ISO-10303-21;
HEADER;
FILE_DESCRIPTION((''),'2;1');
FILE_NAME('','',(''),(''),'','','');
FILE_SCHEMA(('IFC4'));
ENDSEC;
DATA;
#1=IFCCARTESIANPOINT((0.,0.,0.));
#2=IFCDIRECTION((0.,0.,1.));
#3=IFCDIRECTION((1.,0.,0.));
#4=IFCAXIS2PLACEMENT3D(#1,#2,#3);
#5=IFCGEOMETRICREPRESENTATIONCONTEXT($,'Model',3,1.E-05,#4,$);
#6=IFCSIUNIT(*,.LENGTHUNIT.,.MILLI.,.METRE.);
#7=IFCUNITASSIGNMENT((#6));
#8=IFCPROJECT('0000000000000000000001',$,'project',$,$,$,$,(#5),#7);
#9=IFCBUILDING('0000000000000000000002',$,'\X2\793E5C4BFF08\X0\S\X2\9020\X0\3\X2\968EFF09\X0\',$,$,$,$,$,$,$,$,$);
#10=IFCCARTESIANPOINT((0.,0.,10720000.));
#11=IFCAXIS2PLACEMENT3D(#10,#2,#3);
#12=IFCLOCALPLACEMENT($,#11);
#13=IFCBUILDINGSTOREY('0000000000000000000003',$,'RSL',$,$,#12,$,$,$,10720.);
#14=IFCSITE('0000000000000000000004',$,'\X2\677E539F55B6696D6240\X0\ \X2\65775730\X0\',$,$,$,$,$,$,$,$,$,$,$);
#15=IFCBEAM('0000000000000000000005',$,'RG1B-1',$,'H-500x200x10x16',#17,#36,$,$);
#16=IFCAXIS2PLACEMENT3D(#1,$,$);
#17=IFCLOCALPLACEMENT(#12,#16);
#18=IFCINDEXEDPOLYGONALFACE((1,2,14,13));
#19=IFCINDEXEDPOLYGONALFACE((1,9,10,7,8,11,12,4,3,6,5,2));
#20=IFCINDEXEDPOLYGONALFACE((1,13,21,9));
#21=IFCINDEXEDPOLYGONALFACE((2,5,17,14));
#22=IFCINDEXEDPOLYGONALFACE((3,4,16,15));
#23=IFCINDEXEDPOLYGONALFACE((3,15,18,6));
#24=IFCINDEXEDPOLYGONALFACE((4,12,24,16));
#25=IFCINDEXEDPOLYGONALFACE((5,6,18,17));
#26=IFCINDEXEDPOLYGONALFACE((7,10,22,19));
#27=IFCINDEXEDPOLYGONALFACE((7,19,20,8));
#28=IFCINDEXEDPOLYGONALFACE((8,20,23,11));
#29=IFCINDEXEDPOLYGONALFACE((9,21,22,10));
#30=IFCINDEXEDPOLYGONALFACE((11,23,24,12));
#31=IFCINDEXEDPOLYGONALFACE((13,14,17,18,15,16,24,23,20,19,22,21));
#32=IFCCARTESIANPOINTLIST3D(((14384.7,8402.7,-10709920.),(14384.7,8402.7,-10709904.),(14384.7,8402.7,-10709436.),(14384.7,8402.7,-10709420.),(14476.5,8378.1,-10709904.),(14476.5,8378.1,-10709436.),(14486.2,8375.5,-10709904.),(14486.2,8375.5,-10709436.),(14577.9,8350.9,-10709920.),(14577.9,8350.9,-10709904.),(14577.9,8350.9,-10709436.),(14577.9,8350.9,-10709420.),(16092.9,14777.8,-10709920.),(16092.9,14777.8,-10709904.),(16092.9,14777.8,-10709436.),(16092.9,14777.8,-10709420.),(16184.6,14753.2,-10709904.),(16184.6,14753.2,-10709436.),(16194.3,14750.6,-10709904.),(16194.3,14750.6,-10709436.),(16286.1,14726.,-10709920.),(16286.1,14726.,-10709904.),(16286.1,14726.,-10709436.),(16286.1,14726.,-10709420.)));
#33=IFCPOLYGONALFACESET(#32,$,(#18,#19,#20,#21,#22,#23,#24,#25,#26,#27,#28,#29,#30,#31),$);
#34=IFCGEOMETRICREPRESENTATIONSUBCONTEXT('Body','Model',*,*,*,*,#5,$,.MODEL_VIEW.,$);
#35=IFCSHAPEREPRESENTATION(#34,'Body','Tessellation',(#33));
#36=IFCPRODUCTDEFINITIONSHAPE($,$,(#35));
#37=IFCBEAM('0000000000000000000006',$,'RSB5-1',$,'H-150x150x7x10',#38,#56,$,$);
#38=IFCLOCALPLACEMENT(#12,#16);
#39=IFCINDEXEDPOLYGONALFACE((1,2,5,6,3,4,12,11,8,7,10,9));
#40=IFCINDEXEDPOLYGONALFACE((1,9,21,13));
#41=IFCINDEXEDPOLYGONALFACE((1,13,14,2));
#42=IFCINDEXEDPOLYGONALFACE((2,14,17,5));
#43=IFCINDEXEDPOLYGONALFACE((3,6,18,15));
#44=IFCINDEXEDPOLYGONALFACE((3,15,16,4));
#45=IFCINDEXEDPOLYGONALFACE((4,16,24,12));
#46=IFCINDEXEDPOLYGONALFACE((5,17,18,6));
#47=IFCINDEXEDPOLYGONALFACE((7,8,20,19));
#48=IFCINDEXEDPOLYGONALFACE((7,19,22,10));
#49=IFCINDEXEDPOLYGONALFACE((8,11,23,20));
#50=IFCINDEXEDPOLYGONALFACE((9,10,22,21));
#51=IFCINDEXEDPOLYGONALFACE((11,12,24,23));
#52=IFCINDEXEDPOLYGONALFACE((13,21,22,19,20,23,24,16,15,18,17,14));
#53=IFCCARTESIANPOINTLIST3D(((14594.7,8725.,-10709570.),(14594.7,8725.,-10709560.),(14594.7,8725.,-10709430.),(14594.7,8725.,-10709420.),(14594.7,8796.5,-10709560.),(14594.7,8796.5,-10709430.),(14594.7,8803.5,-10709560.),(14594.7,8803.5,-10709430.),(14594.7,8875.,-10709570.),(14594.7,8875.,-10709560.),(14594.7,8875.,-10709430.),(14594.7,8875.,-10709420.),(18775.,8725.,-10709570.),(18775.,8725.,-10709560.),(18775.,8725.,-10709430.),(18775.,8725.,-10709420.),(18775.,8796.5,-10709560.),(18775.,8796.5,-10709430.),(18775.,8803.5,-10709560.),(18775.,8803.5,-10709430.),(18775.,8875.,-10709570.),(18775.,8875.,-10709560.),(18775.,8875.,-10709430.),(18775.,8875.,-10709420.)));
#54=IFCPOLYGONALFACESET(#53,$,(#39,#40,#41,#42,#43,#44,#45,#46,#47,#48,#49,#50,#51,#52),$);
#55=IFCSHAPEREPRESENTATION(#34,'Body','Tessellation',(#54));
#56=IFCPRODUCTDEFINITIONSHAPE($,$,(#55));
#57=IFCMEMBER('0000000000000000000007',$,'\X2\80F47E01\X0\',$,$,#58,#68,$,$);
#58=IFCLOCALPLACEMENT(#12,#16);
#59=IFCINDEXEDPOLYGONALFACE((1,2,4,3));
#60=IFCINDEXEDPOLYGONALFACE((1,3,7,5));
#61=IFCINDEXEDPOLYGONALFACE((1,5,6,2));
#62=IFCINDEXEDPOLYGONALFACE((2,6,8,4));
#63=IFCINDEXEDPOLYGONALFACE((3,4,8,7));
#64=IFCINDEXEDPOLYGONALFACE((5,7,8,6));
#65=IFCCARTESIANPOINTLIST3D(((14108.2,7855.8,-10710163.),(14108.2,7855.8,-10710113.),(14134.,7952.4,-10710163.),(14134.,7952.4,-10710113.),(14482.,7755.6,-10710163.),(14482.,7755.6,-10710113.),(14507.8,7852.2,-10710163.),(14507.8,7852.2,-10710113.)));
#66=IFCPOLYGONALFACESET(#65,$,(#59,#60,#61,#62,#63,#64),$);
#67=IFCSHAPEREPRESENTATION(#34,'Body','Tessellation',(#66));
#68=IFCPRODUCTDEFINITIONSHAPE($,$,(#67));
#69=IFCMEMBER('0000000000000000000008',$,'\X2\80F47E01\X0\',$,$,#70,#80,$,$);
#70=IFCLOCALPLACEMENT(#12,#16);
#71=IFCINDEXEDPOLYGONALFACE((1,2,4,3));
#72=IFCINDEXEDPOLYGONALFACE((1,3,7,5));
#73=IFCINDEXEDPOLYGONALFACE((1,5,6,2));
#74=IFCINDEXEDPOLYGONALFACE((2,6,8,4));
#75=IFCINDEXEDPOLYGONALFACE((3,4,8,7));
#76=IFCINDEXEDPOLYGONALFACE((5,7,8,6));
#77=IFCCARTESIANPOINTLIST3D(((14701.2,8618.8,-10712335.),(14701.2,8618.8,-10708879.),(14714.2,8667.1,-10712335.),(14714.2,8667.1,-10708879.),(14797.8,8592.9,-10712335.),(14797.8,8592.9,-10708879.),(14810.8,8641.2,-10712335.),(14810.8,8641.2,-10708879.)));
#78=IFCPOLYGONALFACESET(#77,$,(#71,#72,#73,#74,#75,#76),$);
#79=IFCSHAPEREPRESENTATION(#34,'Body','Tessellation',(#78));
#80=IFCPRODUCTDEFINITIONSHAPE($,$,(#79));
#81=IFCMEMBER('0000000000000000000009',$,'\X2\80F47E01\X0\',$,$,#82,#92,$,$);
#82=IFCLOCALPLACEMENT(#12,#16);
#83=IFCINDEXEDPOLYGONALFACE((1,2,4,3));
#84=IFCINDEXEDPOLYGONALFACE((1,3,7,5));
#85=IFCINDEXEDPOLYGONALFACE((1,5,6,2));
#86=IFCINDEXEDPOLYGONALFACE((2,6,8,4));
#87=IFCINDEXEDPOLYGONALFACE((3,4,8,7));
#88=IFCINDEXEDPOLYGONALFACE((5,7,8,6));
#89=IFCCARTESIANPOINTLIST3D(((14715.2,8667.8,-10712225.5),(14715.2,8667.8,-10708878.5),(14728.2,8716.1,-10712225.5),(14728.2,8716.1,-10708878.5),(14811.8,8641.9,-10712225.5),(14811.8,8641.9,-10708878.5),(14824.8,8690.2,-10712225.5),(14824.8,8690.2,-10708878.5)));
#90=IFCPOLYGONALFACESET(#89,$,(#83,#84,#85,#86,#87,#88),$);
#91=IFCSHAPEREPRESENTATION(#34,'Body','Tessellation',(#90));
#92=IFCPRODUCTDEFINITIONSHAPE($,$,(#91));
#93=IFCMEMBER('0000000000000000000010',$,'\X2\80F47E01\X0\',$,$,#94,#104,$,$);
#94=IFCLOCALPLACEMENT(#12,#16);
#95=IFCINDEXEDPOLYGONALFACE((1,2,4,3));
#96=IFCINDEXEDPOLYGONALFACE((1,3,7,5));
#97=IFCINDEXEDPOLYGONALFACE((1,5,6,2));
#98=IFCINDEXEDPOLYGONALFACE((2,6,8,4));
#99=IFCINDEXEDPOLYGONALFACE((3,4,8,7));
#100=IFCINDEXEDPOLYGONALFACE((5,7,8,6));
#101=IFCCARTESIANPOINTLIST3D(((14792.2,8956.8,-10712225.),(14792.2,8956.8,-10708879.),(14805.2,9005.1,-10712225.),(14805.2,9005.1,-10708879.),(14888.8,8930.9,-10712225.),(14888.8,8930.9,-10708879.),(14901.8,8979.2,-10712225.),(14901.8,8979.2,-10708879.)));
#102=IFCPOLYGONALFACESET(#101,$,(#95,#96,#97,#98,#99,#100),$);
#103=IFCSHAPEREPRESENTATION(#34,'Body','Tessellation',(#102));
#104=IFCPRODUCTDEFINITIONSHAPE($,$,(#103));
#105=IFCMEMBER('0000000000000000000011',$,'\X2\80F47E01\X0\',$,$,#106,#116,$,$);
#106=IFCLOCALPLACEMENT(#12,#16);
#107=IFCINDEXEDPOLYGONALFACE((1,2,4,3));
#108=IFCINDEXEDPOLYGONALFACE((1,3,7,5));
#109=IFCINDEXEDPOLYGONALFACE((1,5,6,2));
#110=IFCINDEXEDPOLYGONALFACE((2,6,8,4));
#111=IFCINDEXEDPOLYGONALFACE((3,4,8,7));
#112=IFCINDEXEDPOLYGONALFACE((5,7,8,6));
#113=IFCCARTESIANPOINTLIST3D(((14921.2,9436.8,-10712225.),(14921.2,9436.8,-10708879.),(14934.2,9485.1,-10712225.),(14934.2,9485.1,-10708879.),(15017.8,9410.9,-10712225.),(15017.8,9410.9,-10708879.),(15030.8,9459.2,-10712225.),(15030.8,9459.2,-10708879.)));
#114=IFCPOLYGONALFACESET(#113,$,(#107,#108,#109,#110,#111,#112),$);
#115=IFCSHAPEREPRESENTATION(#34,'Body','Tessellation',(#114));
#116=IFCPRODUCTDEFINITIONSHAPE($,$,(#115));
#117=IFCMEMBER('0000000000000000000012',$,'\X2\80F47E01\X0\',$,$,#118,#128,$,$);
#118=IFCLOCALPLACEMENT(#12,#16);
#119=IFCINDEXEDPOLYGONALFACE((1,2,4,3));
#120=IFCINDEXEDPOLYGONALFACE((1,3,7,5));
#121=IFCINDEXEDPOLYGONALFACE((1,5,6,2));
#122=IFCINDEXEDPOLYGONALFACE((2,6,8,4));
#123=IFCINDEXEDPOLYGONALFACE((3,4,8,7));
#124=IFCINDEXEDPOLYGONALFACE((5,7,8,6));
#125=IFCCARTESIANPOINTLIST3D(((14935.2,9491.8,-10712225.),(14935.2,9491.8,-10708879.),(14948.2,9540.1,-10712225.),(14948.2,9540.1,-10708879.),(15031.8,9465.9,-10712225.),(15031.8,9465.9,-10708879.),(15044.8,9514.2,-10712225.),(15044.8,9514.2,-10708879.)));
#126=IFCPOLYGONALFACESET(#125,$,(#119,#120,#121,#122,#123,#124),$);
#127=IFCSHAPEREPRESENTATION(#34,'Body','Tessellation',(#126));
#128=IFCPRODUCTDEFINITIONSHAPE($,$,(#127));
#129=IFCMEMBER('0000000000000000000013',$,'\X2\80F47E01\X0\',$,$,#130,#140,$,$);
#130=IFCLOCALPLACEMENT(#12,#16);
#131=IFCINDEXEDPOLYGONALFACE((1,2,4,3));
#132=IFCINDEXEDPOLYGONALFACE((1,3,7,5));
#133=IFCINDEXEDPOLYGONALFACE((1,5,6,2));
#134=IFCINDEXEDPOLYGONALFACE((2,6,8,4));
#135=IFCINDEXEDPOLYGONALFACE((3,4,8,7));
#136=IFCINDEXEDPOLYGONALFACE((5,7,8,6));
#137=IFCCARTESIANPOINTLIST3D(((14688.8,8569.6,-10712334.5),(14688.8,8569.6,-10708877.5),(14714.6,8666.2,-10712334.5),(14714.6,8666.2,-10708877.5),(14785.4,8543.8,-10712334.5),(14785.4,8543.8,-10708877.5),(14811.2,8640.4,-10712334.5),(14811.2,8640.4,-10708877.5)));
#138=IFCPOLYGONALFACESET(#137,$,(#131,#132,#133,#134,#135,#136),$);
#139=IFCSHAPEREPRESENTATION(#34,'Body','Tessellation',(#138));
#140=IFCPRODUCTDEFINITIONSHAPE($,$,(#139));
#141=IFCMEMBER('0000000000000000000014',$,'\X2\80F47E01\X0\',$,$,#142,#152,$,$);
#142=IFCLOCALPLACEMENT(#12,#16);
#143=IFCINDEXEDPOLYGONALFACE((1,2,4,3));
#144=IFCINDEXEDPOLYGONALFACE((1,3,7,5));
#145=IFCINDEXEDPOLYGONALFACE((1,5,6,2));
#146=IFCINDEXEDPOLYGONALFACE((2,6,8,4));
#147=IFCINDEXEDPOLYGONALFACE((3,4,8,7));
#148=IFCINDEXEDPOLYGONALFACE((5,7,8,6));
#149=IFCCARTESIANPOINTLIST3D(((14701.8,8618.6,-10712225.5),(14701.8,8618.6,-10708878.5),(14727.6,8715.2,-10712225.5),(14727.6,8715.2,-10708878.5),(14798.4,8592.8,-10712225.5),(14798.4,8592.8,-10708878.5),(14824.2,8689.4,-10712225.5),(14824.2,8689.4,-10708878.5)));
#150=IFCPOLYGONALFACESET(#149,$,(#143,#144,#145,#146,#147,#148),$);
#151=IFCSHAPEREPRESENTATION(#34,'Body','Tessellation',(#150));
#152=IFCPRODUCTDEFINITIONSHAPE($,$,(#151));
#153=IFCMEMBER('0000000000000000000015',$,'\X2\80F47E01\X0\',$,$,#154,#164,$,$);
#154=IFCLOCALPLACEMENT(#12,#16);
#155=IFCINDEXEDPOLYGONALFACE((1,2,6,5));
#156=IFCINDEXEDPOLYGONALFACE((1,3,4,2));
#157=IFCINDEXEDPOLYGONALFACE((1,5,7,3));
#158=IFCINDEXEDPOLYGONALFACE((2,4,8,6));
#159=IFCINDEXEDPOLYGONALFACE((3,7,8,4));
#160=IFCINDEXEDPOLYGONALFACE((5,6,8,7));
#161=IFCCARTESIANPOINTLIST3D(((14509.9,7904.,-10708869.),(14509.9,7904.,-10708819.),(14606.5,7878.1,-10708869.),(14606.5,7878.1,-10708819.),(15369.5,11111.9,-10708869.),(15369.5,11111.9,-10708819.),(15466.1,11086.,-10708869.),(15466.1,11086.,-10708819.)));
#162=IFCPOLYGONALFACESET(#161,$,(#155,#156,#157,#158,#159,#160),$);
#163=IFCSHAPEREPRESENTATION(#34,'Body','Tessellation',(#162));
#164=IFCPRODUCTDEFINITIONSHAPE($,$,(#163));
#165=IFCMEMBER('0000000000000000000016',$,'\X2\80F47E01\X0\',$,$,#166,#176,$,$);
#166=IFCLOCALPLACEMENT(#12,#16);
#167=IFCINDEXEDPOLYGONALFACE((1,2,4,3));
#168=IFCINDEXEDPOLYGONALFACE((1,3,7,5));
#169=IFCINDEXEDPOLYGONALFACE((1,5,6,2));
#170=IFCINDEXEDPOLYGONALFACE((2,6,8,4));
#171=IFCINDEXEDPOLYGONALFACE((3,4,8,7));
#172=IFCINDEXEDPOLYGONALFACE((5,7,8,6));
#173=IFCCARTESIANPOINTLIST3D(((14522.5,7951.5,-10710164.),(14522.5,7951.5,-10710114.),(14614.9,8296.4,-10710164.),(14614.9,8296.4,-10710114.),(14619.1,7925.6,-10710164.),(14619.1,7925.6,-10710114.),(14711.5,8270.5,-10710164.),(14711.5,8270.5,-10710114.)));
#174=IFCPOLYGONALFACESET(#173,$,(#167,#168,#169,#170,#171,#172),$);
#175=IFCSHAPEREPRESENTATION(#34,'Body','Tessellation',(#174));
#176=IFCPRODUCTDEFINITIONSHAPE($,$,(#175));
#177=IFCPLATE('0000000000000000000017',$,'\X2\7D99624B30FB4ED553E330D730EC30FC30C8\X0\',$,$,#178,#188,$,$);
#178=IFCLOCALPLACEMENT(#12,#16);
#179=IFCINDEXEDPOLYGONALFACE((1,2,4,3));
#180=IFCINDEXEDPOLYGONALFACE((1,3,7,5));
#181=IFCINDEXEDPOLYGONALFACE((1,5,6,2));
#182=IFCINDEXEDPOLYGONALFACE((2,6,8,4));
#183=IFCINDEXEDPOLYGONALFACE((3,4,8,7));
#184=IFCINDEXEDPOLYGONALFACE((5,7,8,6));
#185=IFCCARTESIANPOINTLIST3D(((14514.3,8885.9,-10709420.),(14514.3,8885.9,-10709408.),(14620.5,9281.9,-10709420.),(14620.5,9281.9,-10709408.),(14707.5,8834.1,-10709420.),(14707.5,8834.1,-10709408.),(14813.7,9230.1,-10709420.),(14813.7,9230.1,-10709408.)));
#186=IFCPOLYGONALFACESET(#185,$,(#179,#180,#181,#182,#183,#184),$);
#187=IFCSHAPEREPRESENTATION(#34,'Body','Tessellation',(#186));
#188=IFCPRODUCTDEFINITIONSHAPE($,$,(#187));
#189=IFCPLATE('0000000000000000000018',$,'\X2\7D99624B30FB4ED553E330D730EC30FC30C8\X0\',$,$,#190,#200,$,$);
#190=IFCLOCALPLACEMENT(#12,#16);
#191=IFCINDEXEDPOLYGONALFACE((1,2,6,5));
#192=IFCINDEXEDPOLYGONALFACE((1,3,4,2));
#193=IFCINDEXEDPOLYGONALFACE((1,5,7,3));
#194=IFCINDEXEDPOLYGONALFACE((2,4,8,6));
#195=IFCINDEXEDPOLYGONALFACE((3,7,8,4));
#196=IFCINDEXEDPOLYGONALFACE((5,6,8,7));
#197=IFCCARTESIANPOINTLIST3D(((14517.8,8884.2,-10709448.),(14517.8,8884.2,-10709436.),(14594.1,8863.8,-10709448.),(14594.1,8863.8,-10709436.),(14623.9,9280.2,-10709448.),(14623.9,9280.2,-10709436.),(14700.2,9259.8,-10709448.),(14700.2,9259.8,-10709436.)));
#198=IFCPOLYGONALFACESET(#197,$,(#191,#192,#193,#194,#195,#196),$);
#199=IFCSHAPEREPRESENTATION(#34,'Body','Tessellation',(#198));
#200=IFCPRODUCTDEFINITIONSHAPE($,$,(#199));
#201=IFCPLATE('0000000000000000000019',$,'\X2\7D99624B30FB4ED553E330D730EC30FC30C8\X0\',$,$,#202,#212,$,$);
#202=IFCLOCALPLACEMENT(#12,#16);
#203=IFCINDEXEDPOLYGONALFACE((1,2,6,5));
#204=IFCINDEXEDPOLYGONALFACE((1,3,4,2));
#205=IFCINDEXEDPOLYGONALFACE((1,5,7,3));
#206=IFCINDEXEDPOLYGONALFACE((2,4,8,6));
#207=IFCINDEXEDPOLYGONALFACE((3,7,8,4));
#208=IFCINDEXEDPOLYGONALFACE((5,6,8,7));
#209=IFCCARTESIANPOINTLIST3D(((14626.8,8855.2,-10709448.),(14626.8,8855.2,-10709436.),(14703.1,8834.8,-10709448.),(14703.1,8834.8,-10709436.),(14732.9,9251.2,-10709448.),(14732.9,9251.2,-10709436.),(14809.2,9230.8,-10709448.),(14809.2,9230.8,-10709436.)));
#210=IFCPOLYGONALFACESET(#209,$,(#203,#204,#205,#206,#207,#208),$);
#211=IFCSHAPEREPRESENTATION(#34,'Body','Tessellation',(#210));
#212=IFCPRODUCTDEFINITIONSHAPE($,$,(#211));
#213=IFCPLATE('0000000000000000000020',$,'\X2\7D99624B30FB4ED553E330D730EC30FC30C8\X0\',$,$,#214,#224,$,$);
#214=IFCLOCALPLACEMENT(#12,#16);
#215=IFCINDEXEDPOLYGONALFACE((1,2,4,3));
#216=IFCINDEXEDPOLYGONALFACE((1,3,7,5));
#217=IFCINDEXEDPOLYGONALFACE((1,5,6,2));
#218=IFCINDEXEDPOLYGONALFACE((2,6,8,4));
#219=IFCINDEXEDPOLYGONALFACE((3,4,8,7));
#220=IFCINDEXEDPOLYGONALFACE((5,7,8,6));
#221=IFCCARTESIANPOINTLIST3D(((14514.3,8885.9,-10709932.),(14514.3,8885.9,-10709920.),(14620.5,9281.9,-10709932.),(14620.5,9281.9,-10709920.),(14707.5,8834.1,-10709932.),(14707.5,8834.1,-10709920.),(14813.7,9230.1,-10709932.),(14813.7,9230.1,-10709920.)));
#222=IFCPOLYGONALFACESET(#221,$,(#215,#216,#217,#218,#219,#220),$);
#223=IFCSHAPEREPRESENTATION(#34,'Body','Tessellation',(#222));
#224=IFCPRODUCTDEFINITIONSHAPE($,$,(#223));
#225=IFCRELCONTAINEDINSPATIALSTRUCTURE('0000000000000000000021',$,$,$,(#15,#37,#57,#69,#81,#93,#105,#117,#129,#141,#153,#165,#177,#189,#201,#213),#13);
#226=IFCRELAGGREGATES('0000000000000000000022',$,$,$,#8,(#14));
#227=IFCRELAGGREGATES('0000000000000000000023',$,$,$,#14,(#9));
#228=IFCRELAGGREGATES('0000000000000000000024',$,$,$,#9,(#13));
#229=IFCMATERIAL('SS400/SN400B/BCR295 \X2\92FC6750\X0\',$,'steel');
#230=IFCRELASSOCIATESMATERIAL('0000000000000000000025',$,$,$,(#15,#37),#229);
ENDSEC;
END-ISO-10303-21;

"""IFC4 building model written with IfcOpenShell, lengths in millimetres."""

from ifc_helpers import new_model, si_unit, frame, origin, origin_with_axes, place, context, subcontext, project, spatial, rectangle, i_section, extrude, material, element, save


model = new_model("IFC4")

# Units and contexts
model_context = context("Model", 3, precision=1e-05, world=origin_with_axes())
body_context = subcontext(model_context, "Body", "Model", "MODEL_VIEW")
ifc_project = project(units=[si_unit("LENGTHUNIT", "METRE", prefix="MILLI")], contexts=[model_context])

# Site, building, storey
site = spatial("IfcSite", under=ifc_project, Name="松原営業所 敷地")
building = spatial("IfcBuilding", under=site, Name="社屋（S造3階）")
storey_placement = place(None, frame((0.0, 0.0, 10720000.0), z_axis=(0.0, 0.0, 1.0), x_axis=(1.0, 0.0, 0.0)))
storey = spatial("IfcBuildingStorey", under=building, at=storey_placement, Name="RSL", Elevation=10720.0)

# Beams
ifc_material = material(Name="SS400/SN400B/BCR295 鋼材", Category="steel")
beam_1_placement = place(storey_placement, frame((14481.3, 8376.8, -10709420.0), z_axis=(0.258812, 0.965928, 0.0), x_axis=(-0.965928, 0.258812, 0.0)))
element("IfcBeam", 1, at=beam_1_placement, inside=storey, material=ifc_material, Name="RG1B-1", ObjectType="H-500x200x10x16", context=body_context, shape_type="SweptSolid", body=[
    extrude(i_section(OverallWidth=200.0, OverallDepth=500.0, WebThickness=10.0, FlangeThickness=16.0), frame((0.0, -250.0, 0.0)), (0.0, 0.0, 1.0), 6600.0),
])
beam_2_placement = place(storey_placement, frame((14594.7, 8800.0, -10709420.0), z_axis=(1.0, 0.0, 0.0), x_axis=(0.0, 1.0, 0.0)))
element("IfcBeam", 2, at=beam_2_placement, inside=storey, material=ifc_material, Name="RSB5-1", ObjectType="H-150x150x7x10", context=body_context, shape_type="SweptSolid", body=[
    extrude(i_section(OverallWidth=150.0, OverallDepth=150.0, WebThickness=7.0, FlangeThickness=10.0), frame((0.0, -75.0, 0.0)), (0.0, 0.0, 1.0), 4180.3),
])

# Members
member_1_placement = place(storey_placement, frame((14121.1, 7904.1, -10710138.0), z_axis=(0.965926, -0.258819, 0.0), x_axis=(0.258819, 0.965926, 0.0)))
element("IfcMember", 3, at=member_1_placement, inside=storey, Name="胴縁", context=body_context, shape_type="SweptSolid", body=[
    extrude(rectangle(XDim=100.0, YDim=50.0), origin(), (0.0, 0.0, 1.0), 387.0),
])
member_2_placement = place(storey_placement, frame((14749.5, 8605.9, -10710607.0), z_axis=(0.258819, 0.965926, 0.0), x_axis=(-0.965926, 0.258819, 0.0)))
element("IfcMember", 4, at=member_2_placement, inside=storey, Name="胴縁", context=body_context, shape_type="SweptSolid", body=[
    extrude(rectangle(XDim=100.0, YDim=3456.0), origin(), (0.0, 0.0, 1.0), 50.0),
])
member_3_placement = place(storey_placement, frame((14763.5, 8654.9, -10710552.0), z_axis=(0.258819, 0.965926, 0.0), x_axis=(-0.965926, 0.258819, 0.0)))
element("IfcMember", 5, at=member_3_placement, inside=storey, Name="胴縁", context=body_context, shape_type="SweptSolid", body=[
    extrude(rectangle(XDim=100.0, YDim=3347.0), origin(), (0.0, 0.0, 1.0), 50.0),
])
for number, where, z_axis, x_axis, name in (
    (6, (14840.5, 8943.9, -10710552.0), (0.258819, 0.965926, 0.0), (-0.965926, 0.258819, 0.0), "胴縁"),
    (7, (14969.5, 9423.9, -10710552.0), (0.258819, 0.965926, 0.0), (-0.965926, 0.258819, 0.0), "胴縁"),
    (8, (14983.5, 9478.9, -10710552.0), (0.258819, 0.965926, 0.0), (-0.965926, 0.258819, 0.0), "胴縁"),
):
    element("IfcMember", number, at=place(storey_placement, frame(where, z_axis=z_axis, x_axis=x_axis)), inside=storey, Name=name, context=body_context, shape_type="SweptSolid", body=[
        extrude(rectangle(XDim=100.0, YDim=3346.0), origin(), (0.0, 0.0, 1.0), 50.0),
    ])
member_4_placement = place(storey_placement, frame((14737.1, 8556.7, -10710606.0), z_axis=(0.258819, 0.965926, 0.0), x_axis=(-0.965926, 0.258819, 0.0)))
element("IfcMember", 9, at=member_4_placement, inside=storey, Name="胴縁", context=body_context, shape_type="SweptSolid", body=[
    extrude(rectangle(XDim=100.0, YDim=3457.0), origin(), (0.0, 0.0, 1.0), 100.0),
])
member_5_placement = place(storey_placement, frame((14750.1, 8605.7, -10710552.0), z_axis=(0.258819, 0.965926, 0.0), x_axis=(-0.965926, 0.258819, 0.0)))
element("IfcMember", 10, at=member_5_placement, inside=storey, Name="胴縁", context=body_context, shape_type="SweptSolid", body=[
    extrude(rectangle(XDim=100.0, YDim=3347.0), origin(), (0.0, 0.0, 1.0), 100.0),
])
member_6_placement = place(storey_placement, frame((14558.2, 7891.1, -10708844.0), z_axis=(0.258819, 0.965926, 0.0), x_axis=(-0.965926, 0.258819, 0.0)))
element("IfcMember", 11, at=member_6_placement, inside=storey, Name="胴縁", context=body_context, shape_type="SweptSolid", body=[
    extrude(rectangle(XDim=100.0, YDim=50.0), origin(), (0.0, 0.0, 1.0), 3321.0),
])
member_7_placement = place(storey_placement, frame((14570.8, 7938.6, -10710139.0), z_axis=(0.258819, 0.965926, 0.0), x_axis=(-0.965926, 0.258819, 0.0)))
element("IfcMember", 12, at=member_7_placement, inside=storey, Name="胴縁", context=body_context, shape_type="SweptSolid", body=[
    extrude(rectangle(XDim=100.0, YDim=50.0), origin(), (0.0, 0.0, 1.0), 357.0),
])

# Plates
plate_1_placement = place(storey_placement, frame((14610.9, 8860.0, -10709414.0), z_axis=(0.258819, 0.965926, 0.0), x_axis=(-0.965926, 0.258819, 0.0)))
element("IfcPlate", 13, at=plate_1_placement, inside=storey, Name="継手・仕口プレート", context=body_context, shape_type="SweptSolid", body=[
    extrude(rectangle(XDim=200.0, YDim=12.0), origin(), (0.0, 0.0, 1.0), 410.0),
])
for number, where, z_axis, x_axis, name in (
    (14, (14555.9, 8874.0, -10709442.0), (0.258819, 0.965926, 0.0), (-0.965926, 0.258819, 0.0), "継手・仕口プレート"),
    (15, (14664.9, 8845.0, -10709442.0), (0.258819, 0.965926, 0.0), (-0.965926, 0.258819, 0.0), "継手・仕口プレート"),
):
    element("IfcPlate", number, at=place(storey_placement, frame(where, z_axis=z_axis, x_axis=x_axis)), inside=storey, Name=name, context=body_context, shape_type="SweptSolid", body=[
        extrude(rectangle(XDim=79.0, YDim=12.0), origin(), (0.0, 0.0, 1.0), 410.0),
    ])
plate_2_placement = place(storey_placement, frame((14610.9, 8860.0, -10709926.0), z_axis=(0.258819, 0.965926, 0.0), x_axis=(-0.965926, 0.258819, 0.0)))
element("IfcPlate", 16, at=plate_2_placement, inside=storey, Name="継手・仕口プレート", context=body_context, shape_type="SweptSolid", body=[
    extrude(rectangle(XDim=200.0, YDim=12.0), origin(), (0.0, 0.0, 1.0), 410.0),
])

save(model, "model.ifc")
